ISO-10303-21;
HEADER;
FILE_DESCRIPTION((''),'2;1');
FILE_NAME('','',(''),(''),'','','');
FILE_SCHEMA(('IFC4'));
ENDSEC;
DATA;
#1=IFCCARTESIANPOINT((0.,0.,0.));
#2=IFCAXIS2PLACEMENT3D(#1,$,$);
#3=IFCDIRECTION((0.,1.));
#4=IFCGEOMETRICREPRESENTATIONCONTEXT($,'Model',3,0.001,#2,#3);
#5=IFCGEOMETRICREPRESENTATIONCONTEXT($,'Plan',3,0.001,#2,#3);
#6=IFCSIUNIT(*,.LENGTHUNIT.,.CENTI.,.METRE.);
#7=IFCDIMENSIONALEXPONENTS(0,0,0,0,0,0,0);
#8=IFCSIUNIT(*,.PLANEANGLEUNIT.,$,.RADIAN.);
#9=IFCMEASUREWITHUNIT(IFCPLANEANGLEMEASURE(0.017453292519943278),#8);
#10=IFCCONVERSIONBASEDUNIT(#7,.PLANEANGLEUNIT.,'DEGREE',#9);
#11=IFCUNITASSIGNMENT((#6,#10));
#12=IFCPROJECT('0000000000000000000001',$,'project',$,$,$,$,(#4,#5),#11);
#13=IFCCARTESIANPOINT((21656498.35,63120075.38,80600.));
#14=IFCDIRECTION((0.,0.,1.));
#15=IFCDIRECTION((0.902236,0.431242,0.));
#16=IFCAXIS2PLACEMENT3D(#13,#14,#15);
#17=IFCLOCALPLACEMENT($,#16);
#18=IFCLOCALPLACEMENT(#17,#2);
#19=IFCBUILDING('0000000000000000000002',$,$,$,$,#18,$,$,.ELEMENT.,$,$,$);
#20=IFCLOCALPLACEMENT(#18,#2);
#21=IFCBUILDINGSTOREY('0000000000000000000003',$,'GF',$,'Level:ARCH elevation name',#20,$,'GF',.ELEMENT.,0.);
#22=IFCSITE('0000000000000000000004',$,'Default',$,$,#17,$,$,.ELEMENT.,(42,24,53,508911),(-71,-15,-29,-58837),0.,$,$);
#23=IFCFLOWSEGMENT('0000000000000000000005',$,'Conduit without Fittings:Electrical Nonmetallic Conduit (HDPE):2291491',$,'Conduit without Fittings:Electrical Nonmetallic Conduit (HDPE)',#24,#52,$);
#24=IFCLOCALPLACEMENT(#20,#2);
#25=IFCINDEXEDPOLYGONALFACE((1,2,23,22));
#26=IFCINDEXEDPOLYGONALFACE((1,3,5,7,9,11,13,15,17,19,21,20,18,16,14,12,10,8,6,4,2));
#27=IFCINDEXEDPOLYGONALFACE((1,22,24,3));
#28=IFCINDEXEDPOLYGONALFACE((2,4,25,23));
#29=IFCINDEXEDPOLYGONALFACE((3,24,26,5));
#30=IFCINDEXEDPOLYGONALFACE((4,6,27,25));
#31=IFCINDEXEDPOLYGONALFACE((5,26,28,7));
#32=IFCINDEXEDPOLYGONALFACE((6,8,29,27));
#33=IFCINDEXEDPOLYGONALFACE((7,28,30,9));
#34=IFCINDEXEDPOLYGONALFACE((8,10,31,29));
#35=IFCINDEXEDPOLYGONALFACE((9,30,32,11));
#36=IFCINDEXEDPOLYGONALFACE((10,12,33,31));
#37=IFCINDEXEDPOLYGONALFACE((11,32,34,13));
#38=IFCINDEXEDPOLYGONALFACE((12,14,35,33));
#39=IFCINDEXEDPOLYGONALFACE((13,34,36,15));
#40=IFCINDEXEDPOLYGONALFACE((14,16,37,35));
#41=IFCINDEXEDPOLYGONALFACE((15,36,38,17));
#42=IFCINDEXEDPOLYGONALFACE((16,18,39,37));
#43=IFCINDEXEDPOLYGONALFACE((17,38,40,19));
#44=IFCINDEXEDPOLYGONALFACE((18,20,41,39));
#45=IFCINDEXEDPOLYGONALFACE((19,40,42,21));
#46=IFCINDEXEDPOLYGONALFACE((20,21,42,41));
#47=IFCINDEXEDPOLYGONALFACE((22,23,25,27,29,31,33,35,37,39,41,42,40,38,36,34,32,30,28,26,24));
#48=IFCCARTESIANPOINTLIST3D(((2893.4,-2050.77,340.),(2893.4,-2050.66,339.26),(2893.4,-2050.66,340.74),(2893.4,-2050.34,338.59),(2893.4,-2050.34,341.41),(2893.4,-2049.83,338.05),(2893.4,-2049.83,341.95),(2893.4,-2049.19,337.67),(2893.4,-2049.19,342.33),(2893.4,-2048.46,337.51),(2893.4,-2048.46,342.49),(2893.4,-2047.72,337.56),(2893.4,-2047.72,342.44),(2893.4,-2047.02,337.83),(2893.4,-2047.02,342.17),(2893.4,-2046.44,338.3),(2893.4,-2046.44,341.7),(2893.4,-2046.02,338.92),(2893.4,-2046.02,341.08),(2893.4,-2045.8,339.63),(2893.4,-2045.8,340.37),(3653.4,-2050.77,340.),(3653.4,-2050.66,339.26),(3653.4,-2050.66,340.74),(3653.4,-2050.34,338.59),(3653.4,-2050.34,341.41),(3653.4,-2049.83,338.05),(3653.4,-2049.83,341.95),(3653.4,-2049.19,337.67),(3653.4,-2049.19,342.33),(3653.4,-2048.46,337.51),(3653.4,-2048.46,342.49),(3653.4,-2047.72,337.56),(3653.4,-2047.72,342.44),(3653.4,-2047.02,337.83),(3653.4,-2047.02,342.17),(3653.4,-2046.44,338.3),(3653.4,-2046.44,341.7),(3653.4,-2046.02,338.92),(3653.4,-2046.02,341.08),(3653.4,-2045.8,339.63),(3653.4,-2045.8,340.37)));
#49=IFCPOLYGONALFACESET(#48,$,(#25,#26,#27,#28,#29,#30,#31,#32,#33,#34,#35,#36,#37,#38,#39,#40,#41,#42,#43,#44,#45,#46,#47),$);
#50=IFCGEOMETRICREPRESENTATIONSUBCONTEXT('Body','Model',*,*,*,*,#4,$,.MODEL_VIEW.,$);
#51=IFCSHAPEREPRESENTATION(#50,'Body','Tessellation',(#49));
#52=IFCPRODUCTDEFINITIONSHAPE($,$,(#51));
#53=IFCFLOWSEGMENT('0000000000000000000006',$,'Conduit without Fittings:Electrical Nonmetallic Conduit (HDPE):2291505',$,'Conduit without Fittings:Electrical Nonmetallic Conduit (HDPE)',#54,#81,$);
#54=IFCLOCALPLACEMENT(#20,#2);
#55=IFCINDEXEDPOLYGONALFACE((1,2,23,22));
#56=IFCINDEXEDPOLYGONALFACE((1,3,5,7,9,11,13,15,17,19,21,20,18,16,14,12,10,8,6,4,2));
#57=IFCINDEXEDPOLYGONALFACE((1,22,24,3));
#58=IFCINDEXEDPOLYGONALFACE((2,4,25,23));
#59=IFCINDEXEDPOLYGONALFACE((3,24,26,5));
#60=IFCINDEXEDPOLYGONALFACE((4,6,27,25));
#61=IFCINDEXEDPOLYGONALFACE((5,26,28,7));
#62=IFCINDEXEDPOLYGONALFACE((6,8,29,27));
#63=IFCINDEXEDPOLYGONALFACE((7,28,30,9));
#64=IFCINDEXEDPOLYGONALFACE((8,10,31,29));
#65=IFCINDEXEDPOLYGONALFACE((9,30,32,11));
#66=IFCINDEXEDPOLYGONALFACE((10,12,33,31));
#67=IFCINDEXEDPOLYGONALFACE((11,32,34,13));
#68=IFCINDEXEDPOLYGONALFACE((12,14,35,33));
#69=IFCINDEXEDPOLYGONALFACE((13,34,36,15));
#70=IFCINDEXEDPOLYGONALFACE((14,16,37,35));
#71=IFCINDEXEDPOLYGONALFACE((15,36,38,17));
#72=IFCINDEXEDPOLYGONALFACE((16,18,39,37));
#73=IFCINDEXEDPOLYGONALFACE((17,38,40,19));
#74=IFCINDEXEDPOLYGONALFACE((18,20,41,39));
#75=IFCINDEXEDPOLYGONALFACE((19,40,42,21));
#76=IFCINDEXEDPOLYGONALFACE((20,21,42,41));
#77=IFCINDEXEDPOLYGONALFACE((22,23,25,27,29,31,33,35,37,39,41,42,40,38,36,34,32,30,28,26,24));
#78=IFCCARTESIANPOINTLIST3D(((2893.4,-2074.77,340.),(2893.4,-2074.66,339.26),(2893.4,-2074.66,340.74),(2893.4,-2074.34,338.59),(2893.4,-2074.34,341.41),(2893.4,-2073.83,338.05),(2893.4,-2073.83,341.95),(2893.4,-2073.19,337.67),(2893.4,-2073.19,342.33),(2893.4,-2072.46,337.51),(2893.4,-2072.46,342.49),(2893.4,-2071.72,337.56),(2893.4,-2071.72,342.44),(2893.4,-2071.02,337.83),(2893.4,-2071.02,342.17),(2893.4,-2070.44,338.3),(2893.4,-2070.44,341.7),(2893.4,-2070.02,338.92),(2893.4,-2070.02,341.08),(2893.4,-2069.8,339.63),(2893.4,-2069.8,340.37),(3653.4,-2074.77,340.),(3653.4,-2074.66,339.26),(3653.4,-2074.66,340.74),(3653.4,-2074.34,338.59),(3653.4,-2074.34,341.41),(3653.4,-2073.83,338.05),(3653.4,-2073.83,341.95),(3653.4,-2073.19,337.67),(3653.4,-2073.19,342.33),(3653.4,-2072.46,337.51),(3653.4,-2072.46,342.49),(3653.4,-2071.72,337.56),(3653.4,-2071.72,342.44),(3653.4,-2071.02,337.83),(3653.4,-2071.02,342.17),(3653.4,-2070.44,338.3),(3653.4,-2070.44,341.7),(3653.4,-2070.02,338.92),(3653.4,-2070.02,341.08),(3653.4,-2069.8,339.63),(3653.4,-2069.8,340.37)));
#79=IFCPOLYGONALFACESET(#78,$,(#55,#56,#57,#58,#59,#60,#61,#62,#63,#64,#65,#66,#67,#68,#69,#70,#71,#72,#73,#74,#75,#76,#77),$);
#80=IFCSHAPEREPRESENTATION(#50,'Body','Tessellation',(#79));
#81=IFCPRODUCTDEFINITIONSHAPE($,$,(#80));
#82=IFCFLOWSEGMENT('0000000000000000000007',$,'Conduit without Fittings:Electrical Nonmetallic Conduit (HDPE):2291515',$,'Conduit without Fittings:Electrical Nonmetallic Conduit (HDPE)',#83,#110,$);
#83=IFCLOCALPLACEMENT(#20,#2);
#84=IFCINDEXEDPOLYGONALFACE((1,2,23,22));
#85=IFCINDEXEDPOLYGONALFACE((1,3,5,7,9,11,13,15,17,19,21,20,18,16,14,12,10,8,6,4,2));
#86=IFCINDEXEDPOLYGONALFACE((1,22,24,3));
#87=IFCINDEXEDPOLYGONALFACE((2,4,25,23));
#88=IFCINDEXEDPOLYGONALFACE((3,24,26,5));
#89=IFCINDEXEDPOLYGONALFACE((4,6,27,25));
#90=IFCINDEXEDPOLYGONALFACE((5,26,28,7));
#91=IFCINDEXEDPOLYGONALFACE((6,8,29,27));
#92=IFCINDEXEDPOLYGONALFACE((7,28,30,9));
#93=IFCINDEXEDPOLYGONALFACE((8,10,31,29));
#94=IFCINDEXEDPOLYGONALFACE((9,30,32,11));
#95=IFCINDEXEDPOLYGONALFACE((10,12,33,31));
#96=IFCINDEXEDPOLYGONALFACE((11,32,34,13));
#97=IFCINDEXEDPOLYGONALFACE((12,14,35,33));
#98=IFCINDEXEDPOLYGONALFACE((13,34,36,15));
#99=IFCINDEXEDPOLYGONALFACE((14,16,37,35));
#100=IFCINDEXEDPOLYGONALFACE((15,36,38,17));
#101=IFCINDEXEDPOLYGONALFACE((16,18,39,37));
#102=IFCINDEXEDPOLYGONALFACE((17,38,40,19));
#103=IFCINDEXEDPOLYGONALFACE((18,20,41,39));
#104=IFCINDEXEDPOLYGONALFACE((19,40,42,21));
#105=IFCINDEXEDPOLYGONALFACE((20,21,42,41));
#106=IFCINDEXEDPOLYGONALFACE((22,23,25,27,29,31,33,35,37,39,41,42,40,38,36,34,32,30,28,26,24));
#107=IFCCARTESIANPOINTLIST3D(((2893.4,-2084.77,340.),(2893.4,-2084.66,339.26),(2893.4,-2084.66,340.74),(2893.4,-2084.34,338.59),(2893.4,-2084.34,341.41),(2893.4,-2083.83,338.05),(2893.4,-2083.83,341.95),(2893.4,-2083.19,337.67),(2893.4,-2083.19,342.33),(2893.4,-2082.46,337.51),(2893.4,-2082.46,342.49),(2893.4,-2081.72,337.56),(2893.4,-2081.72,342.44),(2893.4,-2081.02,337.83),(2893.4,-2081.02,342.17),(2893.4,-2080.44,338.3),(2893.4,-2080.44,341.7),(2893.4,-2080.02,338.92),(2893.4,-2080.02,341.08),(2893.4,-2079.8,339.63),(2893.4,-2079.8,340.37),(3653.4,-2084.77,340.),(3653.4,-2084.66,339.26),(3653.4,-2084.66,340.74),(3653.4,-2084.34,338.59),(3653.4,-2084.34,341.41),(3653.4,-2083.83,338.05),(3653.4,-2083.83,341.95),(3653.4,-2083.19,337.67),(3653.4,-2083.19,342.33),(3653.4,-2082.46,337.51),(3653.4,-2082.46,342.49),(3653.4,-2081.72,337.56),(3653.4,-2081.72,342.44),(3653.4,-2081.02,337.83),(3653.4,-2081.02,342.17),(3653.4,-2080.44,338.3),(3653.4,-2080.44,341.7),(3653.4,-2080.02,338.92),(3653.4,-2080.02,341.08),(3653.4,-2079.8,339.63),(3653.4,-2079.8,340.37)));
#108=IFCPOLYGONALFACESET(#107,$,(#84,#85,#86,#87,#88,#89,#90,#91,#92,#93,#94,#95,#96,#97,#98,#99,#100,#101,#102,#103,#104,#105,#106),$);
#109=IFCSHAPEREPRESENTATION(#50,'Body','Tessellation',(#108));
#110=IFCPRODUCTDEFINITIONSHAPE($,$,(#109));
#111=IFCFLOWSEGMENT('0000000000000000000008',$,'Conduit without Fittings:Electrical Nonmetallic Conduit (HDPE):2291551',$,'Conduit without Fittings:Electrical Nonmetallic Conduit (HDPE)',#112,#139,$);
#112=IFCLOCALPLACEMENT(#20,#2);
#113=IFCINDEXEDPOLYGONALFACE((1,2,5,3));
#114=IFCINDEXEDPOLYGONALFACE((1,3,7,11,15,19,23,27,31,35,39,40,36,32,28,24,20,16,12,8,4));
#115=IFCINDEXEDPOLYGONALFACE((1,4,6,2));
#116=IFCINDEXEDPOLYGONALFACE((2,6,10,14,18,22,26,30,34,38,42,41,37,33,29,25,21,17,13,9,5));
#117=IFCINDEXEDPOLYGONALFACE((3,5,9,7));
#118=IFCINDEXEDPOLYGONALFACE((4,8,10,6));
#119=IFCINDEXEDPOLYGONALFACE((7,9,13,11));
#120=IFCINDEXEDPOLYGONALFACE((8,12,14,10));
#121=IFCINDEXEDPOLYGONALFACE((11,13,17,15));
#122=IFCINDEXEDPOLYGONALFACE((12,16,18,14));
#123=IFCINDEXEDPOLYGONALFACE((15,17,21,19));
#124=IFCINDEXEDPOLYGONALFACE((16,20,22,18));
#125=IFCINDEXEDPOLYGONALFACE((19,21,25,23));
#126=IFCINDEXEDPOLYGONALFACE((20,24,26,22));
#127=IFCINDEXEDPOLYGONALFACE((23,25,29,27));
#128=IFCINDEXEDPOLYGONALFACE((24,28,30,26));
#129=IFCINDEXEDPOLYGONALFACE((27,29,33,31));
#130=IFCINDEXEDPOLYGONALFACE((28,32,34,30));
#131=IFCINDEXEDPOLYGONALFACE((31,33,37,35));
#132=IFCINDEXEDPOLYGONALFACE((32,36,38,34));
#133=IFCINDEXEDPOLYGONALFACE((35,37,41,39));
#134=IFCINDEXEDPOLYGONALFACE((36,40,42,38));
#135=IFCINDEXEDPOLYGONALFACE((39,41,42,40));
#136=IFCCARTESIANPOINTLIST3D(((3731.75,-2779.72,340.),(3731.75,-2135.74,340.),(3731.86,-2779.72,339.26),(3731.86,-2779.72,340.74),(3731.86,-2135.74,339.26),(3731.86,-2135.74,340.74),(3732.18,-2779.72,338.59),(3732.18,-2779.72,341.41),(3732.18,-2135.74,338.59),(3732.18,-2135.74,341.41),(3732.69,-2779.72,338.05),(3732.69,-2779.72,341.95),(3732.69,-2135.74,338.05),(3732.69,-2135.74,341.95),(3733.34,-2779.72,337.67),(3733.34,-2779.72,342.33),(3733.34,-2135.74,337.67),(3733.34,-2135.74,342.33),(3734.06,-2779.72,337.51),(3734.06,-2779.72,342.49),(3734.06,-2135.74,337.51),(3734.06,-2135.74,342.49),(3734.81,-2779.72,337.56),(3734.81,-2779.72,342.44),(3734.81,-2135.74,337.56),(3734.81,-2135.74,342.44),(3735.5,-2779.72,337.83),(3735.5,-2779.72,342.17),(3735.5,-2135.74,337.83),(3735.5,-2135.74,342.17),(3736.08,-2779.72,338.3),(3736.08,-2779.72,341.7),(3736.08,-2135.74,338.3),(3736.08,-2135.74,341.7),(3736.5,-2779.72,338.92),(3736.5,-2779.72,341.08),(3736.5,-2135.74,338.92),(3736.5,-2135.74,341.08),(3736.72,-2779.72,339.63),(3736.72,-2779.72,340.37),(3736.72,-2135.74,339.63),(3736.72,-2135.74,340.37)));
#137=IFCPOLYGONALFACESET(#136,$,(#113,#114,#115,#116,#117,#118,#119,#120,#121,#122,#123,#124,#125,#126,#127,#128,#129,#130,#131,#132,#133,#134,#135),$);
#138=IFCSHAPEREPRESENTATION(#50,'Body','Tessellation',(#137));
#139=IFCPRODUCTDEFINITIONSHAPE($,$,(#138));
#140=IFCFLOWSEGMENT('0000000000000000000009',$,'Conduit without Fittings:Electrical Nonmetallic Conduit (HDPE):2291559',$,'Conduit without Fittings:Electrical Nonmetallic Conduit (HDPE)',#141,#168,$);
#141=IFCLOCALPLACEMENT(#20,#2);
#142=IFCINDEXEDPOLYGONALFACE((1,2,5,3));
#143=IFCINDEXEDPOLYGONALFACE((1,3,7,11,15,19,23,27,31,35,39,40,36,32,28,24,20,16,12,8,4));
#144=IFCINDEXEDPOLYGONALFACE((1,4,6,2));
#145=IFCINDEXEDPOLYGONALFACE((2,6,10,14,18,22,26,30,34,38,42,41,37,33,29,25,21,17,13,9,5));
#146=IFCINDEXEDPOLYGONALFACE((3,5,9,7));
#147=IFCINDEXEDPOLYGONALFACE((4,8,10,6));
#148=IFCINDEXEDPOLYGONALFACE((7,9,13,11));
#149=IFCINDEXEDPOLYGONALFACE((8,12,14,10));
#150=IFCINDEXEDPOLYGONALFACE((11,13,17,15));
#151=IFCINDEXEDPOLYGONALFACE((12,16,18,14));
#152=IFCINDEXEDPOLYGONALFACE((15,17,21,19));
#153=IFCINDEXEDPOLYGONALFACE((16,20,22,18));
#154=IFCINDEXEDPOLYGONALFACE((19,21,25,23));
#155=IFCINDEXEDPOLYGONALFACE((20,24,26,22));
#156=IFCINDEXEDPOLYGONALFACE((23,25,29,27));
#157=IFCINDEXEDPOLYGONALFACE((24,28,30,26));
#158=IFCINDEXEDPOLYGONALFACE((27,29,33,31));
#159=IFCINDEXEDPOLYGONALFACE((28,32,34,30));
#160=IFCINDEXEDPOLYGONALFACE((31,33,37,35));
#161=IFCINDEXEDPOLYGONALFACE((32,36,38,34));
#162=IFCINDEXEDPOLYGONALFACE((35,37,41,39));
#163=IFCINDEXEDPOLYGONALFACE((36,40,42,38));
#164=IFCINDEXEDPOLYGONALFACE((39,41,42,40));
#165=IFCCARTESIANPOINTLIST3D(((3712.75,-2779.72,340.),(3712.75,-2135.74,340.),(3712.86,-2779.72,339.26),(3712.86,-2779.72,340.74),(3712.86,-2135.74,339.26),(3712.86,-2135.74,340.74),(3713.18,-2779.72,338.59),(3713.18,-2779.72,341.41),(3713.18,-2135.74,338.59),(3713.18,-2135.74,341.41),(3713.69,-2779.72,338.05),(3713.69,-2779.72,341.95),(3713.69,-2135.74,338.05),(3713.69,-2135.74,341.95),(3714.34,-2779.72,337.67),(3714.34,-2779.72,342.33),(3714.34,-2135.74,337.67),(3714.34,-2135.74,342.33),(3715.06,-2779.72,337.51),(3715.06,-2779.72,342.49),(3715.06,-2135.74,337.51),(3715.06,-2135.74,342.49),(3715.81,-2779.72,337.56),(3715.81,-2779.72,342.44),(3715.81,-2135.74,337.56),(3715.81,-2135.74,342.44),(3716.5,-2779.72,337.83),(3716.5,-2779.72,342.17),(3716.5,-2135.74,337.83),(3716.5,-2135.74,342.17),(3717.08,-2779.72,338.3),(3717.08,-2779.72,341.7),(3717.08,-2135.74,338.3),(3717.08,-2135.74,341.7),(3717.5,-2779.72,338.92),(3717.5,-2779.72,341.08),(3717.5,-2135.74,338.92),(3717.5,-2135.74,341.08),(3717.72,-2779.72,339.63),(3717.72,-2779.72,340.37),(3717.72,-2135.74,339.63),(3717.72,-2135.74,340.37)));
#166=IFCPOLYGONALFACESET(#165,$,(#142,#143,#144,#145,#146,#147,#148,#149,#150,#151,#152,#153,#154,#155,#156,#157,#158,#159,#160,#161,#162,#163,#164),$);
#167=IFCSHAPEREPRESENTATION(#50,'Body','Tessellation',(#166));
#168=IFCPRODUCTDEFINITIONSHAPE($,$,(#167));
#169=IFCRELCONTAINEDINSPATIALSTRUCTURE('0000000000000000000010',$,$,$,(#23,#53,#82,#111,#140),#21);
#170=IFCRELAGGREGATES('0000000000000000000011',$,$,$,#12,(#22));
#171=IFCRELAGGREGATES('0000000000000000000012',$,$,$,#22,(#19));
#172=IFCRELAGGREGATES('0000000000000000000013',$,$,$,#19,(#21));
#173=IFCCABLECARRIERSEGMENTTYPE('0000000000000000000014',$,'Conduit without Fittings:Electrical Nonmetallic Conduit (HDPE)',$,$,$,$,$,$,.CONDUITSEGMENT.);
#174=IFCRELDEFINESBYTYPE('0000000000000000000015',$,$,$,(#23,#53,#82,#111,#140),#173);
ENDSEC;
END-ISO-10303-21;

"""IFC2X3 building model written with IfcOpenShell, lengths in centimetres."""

from ifc_helpers import new_model, entity, si_unit, converted_unit, direction, frame, frame_2d, origin, origin_2d_with_axis, place, context, subcontext, project, spatial, circle, extrude, type_object, element, save


model = new_model("IFC2X3")

# Units and contexts
model_context = context("Model", 3, precision=0.001, world=origin(), true_north=direction((0.0, 1.0)))
plan_context = context("Plan", 3, precision=0.001, world=origin(), true_north=direction((0.0, 1.0)))
body_context = subcontext(model_context, "Body", "Model", "MODEL_VIEW")
ifc_project = project(units=[si_unit("LENGTHUNIT", "METRE", prefix="CENTI"), converted_unit("PLANEANGLEUNIT", "DEGREE", entity("IfcPlaneAngleMeasure", 0.017453292519943278), si_unit("PLANEANGLEUNIT", "RADIAN"), dimensions=[0, 0, 0, 0, 0, 0, 0])], contexts=[model_context, plan_context])

# Site, building, storey
site_placement = place(None, frame((21656498.35, 63120075.38, 80600.0), z_axis=(0.0, 0.0, 1.0), x_axis=(0.902236, 0.431242, 0.0)))
site = spatial("IfcSite", under=ifc_project, at=site_placement, Name="Default", CompositionType="ELEMENT", RefLatitude=(42, 24, 53, 508911), RefLongitude=(-71, -15, -29, -58837), RefElevation=0.0)
building_placement = place(site_placement, origin())
building = spatial("IfcBuilding", under=site, at=building_placement, CompositionType="ELEMENT")
storey_placement = place(building_placement, origin())
storey = spatial("IfcBuildingStorey", under=building, at=storey_placement, Name="GF", ObjectType="Level:ARCH elevation name", LongName="GF", CompositionType="ELEMENT", Elevation=0.0)

# Flow segments
cable_carrier_segment_type_1 = type_object("IfcCableCarrierSegmentType", Name="Conduit without Fittings:Electrical Nonmetallic Conduit (HDPE)", PredefinedType="CONDUITSEGMENT")
flow_segment_1_placement = place(storey_placement, origin())
element("IfcFlowSegment", 1, at=flow_segment_1_placement, inside=storey, type_object=cable_carrier_segment_type_1, Name="Conduit without Fittings:Electrical Nonmetallic Conduit (HDPE):2291491", ObjectType="Conduit without Fittings:Electrical Nonmetallic Conduit (HDPE)", context=body_context, shape_type="SweptSolid", body=[
    extrude(circle(Radius=2.5, at=origin_2d_with_axis()), frame((2893.4, -2048.27, 340.0), z_axis=(1.0, 0.0, 0.0), x_axis=(0.0, -1.0, 0.0)), (0.0, 0.0, 1.0), 760.0),
])
flow_segment_2_placement = place(storey_placement, origin())
element("IfcFlowSegment", 2, at=flow_segment_2_placement, inside=storey, type_object=cable_carrier_segment_type_1, Name="Conduit without Fittings:Electrical Nonmetallic Conduit (HDPE):2291505", ObjectType="Conduit without Fittings:Electrical Nonmetallic Conduit (HDPE)", context=body_context, shape_type="SweptSolid", body=[
    extrude(circle(Radius=2.5, at=origin_2d_with_axis()), frame((2893.4, -2072.27, 340.0), z_axis=(1.0, 0.0, 0.0), x_axis=(0.0, -1.0, 0.0)), (0.0, 0.0, 1.0), 760.0),
])
flow_segment_3_placement = place(storey_placement, origin())
element("IfcFlowSegment", 3, at=flow_segment_3_placement, inside=storey, type_object=cable_carrier_segment_type_1, Name="Conduit without Fittings:Electrical Nonmetallic Conduit (HDPE):2291515", ObjectType="Conduit without Fittings:Electrical Nonmetallic Conduit (HDPE)", context=body_context, shape_type="SweptSolid", body=[
    extrude(circle(Radius=2.5, at=origin_2d_with_axis()), frame((2893.4, -2082.27, 340.0), z_axis=(1.0, 0.0, 0.0), x_axis=(0.0, -1.0, 0.0)), (0.0, 0.0, 1.0), 760.0),
])
flow_segment_4_placement = place(storey_placement, origin())
element("IfcFlowSegment", 4, at=flow_segment_4_placement, inside=storey, type_object=cable_carrier_segment_type_1, Name="Conduit without Fittings:Electrical Nonmetallic Conduit (HDPE):2291551", ObjectType="Conduit without Fittings:Electrical Nonmetallic Conduit (HDPE)", context=body_context, shape_type="SweptSolid", body=[
    extrude(circle(Radius=2.5, at=frame_2d((0.0, 0.0), x_axis=(1.0, 0.0))), frame((3734.25, -2779.72, 340.0), z_axis=(0.0, 1.0, 0.0), x_axis=(-1.0, 0.0, 0.0)), (0.0, 0.0, 1.0), 643.97),
])
flow_segment_5_placement = place(storey_placement, origin())
element("IfcFlowSegment", 5, at=flow_segment_5_placement, inside=storey, type_object=cable_carrier_segment_type_1, Name="Conduit without Fittings:Electrical Nonmetallic Conduit (HDPE):2291559", ObjectType="Conduit without Fittings:Electrical Nonmetallic Conduit (HDPE)", context=body_context, shape_type="SweptSolid", body=[
    extrude(circle(Radius=2.5, at=frame_2d((0.0, 0.0), x_axis=(1.0, 0.0))), frame((3715.25, -2779.72, 340.0), z_axis=(0.0, 1.0, 0.0), x_axis=(-1.0, 0.0, 0.0)), (0.0, 0.0, 1.0), 643.97),
])

save(model, "model.ifc")
